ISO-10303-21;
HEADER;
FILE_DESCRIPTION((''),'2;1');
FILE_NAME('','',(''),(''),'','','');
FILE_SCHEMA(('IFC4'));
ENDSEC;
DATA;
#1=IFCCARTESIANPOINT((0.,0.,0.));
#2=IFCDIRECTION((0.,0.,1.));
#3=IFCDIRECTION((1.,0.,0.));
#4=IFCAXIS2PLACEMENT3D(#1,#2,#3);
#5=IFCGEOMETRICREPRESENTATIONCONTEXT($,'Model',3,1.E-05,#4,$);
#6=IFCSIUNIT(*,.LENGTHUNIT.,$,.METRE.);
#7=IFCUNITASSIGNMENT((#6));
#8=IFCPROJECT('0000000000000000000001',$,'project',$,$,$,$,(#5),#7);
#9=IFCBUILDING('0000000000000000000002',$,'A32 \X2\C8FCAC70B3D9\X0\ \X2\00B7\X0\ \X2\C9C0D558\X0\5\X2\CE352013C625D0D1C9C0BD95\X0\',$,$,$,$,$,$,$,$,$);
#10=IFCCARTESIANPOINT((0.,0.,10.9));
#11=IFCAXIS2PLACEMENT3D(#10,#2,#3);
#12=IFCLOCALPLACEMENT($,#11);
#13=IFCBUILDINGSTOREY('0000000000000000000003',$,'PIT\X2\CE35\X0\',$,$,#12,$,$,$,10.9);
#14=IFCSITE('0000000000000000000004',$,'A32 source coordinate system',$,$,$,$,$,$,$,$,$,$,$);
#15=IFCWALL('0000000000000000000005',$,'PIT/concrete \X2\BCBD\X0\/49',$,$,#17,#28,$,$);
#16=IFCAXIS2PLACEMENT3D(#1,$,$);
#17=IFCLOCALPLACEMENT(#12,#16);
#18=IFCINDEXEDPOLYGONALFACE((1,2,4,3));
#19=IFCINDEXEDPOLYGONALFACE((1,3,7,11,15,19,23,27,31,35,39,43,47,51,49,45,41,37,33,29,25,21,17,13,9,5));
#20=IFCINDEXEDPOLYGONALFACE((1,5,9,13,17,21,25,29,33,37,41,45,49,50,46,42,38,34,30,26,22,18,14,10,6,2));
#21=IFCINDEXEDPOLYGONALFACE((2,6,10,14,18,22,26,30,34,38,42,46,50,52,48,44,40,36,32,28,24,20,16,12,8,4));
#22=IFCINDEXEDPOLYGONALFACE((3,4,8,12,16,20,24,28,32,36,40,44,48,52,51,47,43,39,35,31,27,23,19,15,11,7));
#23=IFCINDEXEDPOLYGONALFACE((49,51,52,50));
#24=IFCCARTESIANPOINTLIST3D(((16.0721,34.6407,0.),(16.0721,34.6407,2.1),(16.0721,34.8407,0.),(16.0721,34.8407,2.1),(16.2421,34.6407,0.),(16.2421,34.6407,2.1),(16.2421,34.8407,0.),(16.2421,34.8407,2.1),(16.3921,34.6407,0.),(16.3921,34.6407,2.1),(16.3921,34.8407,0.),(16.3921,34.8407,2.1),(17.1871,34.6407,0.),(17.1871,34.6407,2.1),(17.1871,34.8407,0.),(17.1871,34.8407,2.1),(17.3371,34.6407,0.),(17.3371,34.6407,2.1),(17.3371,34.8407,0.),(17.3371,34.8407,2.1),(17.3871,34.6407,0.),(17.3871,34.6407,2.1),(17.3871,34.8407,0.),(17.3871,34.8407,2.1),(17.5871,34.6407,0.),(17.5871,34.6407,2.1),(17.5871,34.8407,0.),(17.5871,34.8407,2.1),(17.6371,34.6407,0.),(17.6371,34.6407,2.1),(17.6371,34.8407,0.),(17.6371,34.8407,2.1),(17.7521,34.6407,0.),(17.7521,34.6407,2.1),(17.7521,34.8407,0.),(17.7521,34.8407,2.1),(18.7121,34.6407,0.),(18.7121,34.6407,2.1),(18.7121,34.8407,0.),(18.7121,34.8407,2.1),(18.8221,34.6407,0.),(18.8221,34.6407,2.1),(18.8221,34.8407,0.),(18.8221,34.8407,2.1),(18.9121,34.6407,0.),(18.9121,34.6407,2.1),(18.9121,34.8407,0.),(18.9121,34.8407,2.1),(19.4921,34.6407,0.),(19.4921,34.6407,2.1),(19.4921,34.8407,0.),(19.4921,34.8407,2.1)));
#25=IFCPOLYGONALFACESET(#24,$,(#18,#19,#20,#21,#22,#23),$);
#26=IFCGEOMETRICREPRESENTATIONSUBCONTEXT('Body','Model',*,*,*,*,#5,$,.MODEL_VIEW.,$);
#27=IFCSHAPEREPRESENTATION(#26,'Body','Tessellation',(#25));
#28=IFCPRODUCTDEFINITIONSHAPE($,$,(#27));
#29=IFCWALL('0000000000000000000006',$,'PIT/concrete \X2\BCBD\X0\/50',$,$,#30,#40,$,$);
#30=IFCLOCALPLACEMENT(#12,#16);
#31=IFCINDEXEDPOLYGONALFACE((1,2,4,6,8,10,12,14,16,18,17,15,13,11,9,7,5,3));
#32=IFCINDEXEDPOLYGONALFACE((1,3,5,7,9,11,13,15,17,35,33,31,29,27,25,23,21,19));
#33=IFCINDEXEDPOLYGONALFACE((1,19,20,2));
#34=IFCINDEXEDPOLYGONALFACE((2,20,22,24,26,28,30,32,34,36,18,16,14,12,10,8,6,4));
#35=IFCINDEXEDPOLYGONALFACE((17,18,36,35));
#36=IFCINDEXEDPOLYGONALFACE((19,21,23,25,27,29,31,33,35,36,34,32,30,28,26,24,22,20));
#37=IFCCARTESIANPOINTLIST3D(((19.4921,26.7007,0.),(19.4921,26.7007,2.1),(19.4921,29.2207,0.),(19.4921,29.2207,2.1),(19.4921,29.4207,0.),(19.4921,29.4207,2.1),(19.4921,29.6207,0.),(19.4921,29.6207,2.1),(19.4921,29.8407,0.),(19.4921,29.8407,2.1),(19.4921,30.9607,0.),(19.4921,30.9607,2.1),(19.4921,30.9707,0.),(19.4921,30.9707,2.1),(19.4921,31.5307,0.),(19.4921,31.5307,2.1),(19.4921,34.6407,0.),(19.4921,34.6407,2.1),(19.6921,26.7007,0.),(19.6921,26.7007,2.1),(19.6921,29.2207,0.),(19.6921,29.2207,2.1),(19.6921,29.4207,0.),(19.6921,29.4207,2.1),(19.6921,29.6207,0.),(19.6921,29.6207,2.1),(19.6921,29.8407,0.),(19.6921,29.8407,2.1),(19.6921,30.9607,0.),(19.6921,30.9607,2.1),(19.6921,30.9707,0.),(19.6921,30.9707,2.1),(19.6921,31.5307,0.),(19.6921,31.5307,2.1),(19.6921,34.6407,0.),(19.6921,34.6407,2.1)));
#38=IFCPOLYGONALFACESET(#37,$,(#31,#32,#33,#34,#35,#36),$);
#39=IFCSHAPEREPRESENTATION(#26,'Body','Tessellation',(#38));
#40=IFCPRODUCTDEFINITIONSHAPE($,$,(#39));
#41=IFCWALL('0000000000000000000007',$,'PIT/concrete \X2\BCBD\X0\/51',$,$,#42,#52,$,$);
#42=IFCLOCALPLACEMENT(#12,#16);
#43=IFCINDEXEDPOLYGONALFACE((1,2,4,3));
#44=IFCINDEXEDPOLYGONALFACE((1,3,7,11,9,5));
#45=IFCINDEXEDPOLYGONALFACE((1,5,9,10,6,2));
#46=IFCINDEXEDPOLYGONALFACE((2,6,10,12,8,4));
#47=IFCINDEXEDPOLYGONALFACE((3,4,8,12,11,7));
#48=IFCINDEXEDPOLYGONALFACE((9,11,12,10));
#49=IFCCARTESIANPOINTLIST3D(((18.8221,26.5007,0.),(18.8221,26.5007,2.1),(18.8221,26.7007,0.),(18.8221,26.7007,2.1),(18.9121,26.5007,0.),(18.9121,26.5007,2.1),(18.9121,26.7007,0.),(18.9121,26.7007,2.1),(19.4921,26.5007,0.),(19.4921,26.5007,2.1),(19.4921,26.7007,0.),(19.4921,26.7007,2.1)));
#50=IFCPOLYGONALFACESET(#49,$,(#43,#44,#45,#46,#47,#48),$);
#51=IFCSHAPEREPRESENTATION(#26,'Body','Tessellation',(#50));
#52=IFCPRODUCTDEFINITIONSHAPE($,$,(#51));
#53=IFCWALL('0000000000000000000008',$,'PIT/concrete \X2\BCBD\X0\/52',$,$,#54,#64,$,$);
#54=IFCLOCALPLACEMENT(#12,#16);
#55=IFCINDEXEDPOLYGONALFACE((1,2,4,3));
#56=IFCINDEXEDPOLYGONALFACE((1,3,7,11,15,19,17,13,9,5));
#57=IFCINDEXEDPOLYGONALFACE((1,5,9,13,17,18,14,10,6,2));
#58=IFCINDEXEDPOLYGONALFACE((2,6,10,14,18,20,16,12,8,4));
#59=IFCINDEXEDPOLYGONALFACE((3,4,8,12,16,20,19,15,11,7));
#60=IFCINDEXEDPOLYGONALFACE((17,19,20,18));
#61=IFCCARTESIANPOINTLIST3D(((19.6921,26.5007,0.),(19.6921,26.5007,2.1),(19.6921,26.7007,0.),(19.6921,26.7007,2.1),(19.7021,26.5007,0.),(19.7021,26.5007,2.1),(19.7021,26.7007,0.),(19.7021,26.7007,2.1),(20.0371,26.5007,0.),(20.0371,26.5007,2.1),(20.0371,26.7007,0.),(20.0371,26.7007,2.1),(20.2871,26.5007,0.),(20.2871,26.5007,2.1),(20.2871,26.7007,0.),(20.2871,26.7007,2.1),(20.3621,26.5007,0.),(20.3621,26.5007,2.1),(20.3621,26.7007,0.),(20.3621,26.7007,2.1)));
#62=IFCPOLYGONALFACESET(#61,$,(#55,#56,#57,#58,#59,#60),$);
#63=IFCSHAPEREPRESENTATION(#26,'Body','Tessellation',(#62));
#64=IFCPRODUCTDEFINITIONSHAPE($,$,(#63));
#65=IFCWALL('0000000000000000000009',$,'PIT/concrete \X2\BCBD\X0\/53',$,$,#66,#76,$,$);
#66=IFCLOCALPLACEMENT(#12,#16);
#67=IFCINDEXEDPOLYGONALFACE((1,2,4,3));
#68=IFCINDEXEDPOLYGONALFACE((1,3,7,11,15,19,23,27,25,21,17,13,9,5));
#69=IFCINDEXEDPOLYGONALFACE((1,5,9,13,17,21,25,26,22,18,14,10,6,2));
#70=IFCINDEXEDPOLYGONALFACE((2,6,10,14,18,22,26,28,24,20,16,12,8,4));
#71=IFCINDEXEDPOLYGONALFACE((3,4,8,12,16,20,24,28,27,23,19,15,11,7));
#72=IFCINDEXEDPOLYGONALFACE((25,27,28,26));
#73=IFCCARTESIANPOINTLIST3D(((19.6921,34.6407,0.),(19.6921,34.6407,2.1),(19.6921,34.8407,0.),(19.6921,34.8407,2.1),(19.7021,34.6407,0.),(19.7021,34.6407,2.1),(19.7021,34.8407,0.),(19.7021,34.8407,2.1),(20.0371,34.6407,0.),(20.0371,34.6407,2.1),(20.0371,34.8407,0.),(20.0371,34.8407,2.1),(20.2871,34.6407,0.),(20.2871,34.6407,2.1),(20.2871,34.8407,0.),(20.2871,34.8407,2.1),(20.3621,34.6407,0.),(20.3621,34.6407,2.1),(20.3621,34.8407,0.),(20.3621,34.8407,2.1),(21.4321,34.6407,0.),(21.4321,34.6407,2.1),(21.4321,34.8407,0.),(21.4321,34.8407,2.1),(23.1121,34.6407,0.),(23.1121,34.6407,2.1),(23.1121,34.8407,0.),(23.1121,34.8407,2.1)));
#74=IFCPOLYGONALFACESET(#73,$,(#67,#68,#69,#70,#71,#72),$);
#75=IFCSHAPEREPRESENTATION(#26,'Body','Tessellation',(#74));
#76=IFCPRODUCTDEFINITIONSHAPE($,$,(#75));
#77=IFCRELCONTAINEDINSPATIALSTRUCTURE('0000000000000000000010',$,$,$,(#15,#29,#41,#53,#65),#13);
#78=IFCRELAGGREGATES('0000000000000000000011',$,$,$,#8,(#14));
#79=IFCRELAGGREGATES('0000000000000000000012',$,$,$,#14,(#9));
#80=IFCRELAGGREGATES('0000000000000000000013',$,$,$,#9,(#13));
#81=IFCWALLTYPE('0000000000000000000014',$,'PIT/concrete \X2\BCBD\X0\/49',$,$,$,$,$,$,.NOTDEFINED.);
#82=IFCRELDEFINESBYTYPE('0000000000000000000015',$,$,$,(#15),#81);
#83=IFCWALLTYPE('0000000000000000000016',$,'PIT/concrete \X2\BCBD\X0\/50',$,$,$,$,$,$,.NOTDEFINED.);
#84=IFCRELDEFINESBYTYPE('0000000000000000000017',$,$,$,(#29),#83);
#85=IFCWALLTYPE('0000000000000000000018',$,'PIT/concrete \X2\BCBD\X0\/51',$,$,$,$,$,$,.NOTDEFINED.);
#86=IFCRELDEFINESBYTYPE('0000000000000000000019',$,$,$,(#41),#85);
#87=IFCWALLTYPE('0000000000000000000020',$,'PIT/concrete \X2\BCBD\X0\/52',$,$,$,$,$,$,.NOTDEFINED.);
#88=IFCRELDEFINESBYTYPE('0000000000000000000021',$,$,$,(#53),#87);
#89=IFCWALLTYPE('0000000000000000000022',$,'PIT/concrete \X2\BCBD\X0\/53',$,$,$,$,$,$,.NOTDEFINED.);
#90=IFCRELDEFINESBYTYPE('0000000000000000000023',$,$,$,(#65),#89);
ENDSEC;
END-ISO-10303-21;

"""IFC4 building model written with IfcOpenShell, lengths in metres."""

from ifc_helpers import new_model, si_unit, frame, origin, origin_with_axes, place, context, subcontext, project, spatial, polyline, outline, extrude, source, transform, mapped, type_object, type_shapes, element, save


model = new_model("IFC4")

# Units and contexts
model_context = context("Model", 3, precision=1e-05, world=origin_with_axes())
body_context = subcontext(model_context, "Body", "Model", "MODEL_VIEW")
ifc_project = project(units=[si_unit("LENGTHUNIT", "METRE")], contexts=[model_context])

# Site, building, storey
site = spatial("IfcSite", under=ifc_project, Name="A32 source coordinate system")
building = spatial("IfcBuilding", under=site, Name="A32 주거동 · 지하5층–옥탑지붕")
storey_placement = place(None, frame((0.0, 0.0, 10.9), z_axis=(0.0, 0.0, 1.0), x_axis=(1.0, 0.0, 0.0)))
storey = spatial("IfcBuildingStorey", under=building, at=storey_placement, Name="PIT층", Elevation=10.9)

# Walls
wall_type_1 = type_object("IfcWallType", Name="PIT/concrete 벽/49", PredefinedType="NOTDEFINED")
shared_shape_1 = source(origin(), body_context, "Body", "SweptSolid", [
    extrude(outline(polyline([(16.3921, 34.8407), (17.1871, 34.8407), (17.3371, 34.8407), (17.3871, 34.8407), (17.5871, 34.8407), (17.6371, 34.8407), (17.7521, 34.8407), (18.7121, 34.8407), (18.8221, 34.8407), (18.9121, 34.8407), (19.4921, 34.8407), (19.4921, 34.6407), (18.9121, 34.6407), (18.8221, 34.6407), (18.7121, 34.6407), (17.7521, 34.6407), (17.6371, 34.6407), (17.5871, 34.6407), (17.3871, 34.6407), (17.3371, 34.6407), (17.1871, 34.6407), (16.3921, 34.6407), (16.2421, 34.6407), (16.0721, 34.6407), (16.0721, 34.8407), (16.2421, 34.8407), (16.3921, 34.8407)])), origin(), (0.0, 0.0, 1.0), 2.1),
])
type_shapes(wall_type_1, [shared_shape_1])
wall_1_placement = place(storey_placement, origin_with_axes())
element("IfcWall", 1, at=wall_1_placement, inside=storey, type_object=wall_type_1, Name="PIT/concrete 벽/49", context=body_context, shape_type="MappedRepresentation", body=[
    mapped(shared_shape_1, transform((0.0, 0.0, 0.0), scale=1.0)),
])
wall_type_2 = type_object("IfcWallType", Name="PIT/concrete 벽/50", PredefinedType="NOTDEFINED")
shared_shape_2 = source(origin(), body_context, "Body", "SweptSolid", [
    extrude(outline(polyline([(19.6921, 30.9707), (19.6921, 30.9607), (19.6921, 29.8407), (19.6921, 29.6207), (19.6921, 29.4207), (19.6921, 29.2207), (19.6921, 26.7007), (19.4921, 26.7007), (19.4921, 29.2207), (19.4921, 29.4207), (19.4921, 29.6207), (19.4921, 29.8407), (19.4921, 30.9607), (19.4921, 30.9707), (19.4921, 31.5307), (19.4921, 34.6407), (19.6921, 34.6407), (19.6921, 31.5307), (19.6921, 30.9707)])), origin(), (0.0, 0.0, 1.0), 2.1),
])
type_shapes(wall_type_2, [shared_shape_2])
wall_2_placement = place(storey_placement, origin_with_axes())
element("IfcWall", 2, at=wall_2_placement, inside=storey, type_object=wall_type_2, Name="PIT/concrete 벽/50", context=body_context, shape_type="MappedRepresentation", body=[
    mapped(shared_shape_2, transform((0.0, 0.0, 0.0), scale=1.0)),
])
wall_type_3 = type_object("IfcWallType", Name="PIT/concrete 벽/51", PredefinedType="NOTDEFINED")
shared_shape_3 = source(origin(), body_context, "Body", "SweptSolid", [
    extrude(outline(polyline([(18.8221, 26.5007), (18.8221, 26.7007), (18.9121, 26.7007), (19.4921, 26.7007), (19.4921, 26.5007), (18.9121, 26.5007), (18.8221, 26.5007)])), origin(), (0.0, 0.0, 1.0), 2.1),
])
type_shapes(wall_type_3, [shared_shape_3])
wall_3_placement = place(storey_placement, origin_with_axes())
element("IfcWall", 3, at=wall_3_placement, inside=storey, type_object=wall_type_3, Name="PIT/concrete 벽/51", context=body_context, shape_type="MappedRepresentation", body=[
    mapped(shared_shape_3, transform((0.0, 0.0, 0.0), scale=1.0)),
])
wall_type_4 = type_object("IfcWallType", Name="PIT/concrete 벽/52", PredefinedType="NOTDEFINED")
shared_shape_4 = source(origin(), body_context, "Body", "SweptSolid", [
    extrude(outline(polyline([(20.2871, 26.7007), (20.3621, 26.7007), (20.3621, 26.5007), (20.2871, 26.5007), (20.0371, 26.5007), (19.7021, 26.5007), (19.6921, 26.5007), (19.6921, 26.7007), (19.7021, 26.7007), (20.0371, 26.7007), (20.2871, 26.7007)])), origin(), (0.0, 0.0, 1.0), 2.1),
])
type_shapes(wall_type_4, [shared_shape_4])
wall_4_placement = place(storey_placement, origin_with_axes())
element("IfcWall", 4, at=wall_4_placement, inside=storey, type_object=wall_type_4, Name="PIT/concrete 벽/52", context=body_context, shape_type="MappedRepresentation", body=[
    mapped(shared_shape_4, transform((0.0, 0.0, 0.0), scale=1.0)),
])
wall_type_5 = type_object("IfcWallType", Name="PIT/concrete 벽/53", PredefinedType="NOTDEFINED")
shared_shape_5 = source(origin(), body_context, "Body", "SweptSolid", [
    extrude(outline(polyline([(20.0371, 34.8407), (20.2871, 34.8407), (20.3621, 34.8407), (21.4321, 34.8407), (23.1121, 34.8407), (23.1121, 34.6407), (21.4321, 34.6407), (20.3621, 34.6407), (20.2871, 34.6407), (20.0371, 34.6407), (19.7021, 34.6407), (19.6921, 34.6407), (19.6921, 34.8407), (19.7021, 34.8407), (20.0371, 34.8407)])), origin(), (0.0, 0.0, 1.0), 2.1),
])
type_shapes(wall_type_5, [shared_shape_5])
wall_5_placement = place(storey_placement, origin_with_axes())
element("IfcWall", 5, at=wall_5_placement, inside=storey, type_object=wall_type_5, Name="PIT/concrete 벽/53", context=body_context, shape_type="MappedRepresentation", body=[
    mapped(shared_shape_5, transform((0.0, 0.0, 0.0), scale=1.0)),
])

save(model, "model.ifc")
